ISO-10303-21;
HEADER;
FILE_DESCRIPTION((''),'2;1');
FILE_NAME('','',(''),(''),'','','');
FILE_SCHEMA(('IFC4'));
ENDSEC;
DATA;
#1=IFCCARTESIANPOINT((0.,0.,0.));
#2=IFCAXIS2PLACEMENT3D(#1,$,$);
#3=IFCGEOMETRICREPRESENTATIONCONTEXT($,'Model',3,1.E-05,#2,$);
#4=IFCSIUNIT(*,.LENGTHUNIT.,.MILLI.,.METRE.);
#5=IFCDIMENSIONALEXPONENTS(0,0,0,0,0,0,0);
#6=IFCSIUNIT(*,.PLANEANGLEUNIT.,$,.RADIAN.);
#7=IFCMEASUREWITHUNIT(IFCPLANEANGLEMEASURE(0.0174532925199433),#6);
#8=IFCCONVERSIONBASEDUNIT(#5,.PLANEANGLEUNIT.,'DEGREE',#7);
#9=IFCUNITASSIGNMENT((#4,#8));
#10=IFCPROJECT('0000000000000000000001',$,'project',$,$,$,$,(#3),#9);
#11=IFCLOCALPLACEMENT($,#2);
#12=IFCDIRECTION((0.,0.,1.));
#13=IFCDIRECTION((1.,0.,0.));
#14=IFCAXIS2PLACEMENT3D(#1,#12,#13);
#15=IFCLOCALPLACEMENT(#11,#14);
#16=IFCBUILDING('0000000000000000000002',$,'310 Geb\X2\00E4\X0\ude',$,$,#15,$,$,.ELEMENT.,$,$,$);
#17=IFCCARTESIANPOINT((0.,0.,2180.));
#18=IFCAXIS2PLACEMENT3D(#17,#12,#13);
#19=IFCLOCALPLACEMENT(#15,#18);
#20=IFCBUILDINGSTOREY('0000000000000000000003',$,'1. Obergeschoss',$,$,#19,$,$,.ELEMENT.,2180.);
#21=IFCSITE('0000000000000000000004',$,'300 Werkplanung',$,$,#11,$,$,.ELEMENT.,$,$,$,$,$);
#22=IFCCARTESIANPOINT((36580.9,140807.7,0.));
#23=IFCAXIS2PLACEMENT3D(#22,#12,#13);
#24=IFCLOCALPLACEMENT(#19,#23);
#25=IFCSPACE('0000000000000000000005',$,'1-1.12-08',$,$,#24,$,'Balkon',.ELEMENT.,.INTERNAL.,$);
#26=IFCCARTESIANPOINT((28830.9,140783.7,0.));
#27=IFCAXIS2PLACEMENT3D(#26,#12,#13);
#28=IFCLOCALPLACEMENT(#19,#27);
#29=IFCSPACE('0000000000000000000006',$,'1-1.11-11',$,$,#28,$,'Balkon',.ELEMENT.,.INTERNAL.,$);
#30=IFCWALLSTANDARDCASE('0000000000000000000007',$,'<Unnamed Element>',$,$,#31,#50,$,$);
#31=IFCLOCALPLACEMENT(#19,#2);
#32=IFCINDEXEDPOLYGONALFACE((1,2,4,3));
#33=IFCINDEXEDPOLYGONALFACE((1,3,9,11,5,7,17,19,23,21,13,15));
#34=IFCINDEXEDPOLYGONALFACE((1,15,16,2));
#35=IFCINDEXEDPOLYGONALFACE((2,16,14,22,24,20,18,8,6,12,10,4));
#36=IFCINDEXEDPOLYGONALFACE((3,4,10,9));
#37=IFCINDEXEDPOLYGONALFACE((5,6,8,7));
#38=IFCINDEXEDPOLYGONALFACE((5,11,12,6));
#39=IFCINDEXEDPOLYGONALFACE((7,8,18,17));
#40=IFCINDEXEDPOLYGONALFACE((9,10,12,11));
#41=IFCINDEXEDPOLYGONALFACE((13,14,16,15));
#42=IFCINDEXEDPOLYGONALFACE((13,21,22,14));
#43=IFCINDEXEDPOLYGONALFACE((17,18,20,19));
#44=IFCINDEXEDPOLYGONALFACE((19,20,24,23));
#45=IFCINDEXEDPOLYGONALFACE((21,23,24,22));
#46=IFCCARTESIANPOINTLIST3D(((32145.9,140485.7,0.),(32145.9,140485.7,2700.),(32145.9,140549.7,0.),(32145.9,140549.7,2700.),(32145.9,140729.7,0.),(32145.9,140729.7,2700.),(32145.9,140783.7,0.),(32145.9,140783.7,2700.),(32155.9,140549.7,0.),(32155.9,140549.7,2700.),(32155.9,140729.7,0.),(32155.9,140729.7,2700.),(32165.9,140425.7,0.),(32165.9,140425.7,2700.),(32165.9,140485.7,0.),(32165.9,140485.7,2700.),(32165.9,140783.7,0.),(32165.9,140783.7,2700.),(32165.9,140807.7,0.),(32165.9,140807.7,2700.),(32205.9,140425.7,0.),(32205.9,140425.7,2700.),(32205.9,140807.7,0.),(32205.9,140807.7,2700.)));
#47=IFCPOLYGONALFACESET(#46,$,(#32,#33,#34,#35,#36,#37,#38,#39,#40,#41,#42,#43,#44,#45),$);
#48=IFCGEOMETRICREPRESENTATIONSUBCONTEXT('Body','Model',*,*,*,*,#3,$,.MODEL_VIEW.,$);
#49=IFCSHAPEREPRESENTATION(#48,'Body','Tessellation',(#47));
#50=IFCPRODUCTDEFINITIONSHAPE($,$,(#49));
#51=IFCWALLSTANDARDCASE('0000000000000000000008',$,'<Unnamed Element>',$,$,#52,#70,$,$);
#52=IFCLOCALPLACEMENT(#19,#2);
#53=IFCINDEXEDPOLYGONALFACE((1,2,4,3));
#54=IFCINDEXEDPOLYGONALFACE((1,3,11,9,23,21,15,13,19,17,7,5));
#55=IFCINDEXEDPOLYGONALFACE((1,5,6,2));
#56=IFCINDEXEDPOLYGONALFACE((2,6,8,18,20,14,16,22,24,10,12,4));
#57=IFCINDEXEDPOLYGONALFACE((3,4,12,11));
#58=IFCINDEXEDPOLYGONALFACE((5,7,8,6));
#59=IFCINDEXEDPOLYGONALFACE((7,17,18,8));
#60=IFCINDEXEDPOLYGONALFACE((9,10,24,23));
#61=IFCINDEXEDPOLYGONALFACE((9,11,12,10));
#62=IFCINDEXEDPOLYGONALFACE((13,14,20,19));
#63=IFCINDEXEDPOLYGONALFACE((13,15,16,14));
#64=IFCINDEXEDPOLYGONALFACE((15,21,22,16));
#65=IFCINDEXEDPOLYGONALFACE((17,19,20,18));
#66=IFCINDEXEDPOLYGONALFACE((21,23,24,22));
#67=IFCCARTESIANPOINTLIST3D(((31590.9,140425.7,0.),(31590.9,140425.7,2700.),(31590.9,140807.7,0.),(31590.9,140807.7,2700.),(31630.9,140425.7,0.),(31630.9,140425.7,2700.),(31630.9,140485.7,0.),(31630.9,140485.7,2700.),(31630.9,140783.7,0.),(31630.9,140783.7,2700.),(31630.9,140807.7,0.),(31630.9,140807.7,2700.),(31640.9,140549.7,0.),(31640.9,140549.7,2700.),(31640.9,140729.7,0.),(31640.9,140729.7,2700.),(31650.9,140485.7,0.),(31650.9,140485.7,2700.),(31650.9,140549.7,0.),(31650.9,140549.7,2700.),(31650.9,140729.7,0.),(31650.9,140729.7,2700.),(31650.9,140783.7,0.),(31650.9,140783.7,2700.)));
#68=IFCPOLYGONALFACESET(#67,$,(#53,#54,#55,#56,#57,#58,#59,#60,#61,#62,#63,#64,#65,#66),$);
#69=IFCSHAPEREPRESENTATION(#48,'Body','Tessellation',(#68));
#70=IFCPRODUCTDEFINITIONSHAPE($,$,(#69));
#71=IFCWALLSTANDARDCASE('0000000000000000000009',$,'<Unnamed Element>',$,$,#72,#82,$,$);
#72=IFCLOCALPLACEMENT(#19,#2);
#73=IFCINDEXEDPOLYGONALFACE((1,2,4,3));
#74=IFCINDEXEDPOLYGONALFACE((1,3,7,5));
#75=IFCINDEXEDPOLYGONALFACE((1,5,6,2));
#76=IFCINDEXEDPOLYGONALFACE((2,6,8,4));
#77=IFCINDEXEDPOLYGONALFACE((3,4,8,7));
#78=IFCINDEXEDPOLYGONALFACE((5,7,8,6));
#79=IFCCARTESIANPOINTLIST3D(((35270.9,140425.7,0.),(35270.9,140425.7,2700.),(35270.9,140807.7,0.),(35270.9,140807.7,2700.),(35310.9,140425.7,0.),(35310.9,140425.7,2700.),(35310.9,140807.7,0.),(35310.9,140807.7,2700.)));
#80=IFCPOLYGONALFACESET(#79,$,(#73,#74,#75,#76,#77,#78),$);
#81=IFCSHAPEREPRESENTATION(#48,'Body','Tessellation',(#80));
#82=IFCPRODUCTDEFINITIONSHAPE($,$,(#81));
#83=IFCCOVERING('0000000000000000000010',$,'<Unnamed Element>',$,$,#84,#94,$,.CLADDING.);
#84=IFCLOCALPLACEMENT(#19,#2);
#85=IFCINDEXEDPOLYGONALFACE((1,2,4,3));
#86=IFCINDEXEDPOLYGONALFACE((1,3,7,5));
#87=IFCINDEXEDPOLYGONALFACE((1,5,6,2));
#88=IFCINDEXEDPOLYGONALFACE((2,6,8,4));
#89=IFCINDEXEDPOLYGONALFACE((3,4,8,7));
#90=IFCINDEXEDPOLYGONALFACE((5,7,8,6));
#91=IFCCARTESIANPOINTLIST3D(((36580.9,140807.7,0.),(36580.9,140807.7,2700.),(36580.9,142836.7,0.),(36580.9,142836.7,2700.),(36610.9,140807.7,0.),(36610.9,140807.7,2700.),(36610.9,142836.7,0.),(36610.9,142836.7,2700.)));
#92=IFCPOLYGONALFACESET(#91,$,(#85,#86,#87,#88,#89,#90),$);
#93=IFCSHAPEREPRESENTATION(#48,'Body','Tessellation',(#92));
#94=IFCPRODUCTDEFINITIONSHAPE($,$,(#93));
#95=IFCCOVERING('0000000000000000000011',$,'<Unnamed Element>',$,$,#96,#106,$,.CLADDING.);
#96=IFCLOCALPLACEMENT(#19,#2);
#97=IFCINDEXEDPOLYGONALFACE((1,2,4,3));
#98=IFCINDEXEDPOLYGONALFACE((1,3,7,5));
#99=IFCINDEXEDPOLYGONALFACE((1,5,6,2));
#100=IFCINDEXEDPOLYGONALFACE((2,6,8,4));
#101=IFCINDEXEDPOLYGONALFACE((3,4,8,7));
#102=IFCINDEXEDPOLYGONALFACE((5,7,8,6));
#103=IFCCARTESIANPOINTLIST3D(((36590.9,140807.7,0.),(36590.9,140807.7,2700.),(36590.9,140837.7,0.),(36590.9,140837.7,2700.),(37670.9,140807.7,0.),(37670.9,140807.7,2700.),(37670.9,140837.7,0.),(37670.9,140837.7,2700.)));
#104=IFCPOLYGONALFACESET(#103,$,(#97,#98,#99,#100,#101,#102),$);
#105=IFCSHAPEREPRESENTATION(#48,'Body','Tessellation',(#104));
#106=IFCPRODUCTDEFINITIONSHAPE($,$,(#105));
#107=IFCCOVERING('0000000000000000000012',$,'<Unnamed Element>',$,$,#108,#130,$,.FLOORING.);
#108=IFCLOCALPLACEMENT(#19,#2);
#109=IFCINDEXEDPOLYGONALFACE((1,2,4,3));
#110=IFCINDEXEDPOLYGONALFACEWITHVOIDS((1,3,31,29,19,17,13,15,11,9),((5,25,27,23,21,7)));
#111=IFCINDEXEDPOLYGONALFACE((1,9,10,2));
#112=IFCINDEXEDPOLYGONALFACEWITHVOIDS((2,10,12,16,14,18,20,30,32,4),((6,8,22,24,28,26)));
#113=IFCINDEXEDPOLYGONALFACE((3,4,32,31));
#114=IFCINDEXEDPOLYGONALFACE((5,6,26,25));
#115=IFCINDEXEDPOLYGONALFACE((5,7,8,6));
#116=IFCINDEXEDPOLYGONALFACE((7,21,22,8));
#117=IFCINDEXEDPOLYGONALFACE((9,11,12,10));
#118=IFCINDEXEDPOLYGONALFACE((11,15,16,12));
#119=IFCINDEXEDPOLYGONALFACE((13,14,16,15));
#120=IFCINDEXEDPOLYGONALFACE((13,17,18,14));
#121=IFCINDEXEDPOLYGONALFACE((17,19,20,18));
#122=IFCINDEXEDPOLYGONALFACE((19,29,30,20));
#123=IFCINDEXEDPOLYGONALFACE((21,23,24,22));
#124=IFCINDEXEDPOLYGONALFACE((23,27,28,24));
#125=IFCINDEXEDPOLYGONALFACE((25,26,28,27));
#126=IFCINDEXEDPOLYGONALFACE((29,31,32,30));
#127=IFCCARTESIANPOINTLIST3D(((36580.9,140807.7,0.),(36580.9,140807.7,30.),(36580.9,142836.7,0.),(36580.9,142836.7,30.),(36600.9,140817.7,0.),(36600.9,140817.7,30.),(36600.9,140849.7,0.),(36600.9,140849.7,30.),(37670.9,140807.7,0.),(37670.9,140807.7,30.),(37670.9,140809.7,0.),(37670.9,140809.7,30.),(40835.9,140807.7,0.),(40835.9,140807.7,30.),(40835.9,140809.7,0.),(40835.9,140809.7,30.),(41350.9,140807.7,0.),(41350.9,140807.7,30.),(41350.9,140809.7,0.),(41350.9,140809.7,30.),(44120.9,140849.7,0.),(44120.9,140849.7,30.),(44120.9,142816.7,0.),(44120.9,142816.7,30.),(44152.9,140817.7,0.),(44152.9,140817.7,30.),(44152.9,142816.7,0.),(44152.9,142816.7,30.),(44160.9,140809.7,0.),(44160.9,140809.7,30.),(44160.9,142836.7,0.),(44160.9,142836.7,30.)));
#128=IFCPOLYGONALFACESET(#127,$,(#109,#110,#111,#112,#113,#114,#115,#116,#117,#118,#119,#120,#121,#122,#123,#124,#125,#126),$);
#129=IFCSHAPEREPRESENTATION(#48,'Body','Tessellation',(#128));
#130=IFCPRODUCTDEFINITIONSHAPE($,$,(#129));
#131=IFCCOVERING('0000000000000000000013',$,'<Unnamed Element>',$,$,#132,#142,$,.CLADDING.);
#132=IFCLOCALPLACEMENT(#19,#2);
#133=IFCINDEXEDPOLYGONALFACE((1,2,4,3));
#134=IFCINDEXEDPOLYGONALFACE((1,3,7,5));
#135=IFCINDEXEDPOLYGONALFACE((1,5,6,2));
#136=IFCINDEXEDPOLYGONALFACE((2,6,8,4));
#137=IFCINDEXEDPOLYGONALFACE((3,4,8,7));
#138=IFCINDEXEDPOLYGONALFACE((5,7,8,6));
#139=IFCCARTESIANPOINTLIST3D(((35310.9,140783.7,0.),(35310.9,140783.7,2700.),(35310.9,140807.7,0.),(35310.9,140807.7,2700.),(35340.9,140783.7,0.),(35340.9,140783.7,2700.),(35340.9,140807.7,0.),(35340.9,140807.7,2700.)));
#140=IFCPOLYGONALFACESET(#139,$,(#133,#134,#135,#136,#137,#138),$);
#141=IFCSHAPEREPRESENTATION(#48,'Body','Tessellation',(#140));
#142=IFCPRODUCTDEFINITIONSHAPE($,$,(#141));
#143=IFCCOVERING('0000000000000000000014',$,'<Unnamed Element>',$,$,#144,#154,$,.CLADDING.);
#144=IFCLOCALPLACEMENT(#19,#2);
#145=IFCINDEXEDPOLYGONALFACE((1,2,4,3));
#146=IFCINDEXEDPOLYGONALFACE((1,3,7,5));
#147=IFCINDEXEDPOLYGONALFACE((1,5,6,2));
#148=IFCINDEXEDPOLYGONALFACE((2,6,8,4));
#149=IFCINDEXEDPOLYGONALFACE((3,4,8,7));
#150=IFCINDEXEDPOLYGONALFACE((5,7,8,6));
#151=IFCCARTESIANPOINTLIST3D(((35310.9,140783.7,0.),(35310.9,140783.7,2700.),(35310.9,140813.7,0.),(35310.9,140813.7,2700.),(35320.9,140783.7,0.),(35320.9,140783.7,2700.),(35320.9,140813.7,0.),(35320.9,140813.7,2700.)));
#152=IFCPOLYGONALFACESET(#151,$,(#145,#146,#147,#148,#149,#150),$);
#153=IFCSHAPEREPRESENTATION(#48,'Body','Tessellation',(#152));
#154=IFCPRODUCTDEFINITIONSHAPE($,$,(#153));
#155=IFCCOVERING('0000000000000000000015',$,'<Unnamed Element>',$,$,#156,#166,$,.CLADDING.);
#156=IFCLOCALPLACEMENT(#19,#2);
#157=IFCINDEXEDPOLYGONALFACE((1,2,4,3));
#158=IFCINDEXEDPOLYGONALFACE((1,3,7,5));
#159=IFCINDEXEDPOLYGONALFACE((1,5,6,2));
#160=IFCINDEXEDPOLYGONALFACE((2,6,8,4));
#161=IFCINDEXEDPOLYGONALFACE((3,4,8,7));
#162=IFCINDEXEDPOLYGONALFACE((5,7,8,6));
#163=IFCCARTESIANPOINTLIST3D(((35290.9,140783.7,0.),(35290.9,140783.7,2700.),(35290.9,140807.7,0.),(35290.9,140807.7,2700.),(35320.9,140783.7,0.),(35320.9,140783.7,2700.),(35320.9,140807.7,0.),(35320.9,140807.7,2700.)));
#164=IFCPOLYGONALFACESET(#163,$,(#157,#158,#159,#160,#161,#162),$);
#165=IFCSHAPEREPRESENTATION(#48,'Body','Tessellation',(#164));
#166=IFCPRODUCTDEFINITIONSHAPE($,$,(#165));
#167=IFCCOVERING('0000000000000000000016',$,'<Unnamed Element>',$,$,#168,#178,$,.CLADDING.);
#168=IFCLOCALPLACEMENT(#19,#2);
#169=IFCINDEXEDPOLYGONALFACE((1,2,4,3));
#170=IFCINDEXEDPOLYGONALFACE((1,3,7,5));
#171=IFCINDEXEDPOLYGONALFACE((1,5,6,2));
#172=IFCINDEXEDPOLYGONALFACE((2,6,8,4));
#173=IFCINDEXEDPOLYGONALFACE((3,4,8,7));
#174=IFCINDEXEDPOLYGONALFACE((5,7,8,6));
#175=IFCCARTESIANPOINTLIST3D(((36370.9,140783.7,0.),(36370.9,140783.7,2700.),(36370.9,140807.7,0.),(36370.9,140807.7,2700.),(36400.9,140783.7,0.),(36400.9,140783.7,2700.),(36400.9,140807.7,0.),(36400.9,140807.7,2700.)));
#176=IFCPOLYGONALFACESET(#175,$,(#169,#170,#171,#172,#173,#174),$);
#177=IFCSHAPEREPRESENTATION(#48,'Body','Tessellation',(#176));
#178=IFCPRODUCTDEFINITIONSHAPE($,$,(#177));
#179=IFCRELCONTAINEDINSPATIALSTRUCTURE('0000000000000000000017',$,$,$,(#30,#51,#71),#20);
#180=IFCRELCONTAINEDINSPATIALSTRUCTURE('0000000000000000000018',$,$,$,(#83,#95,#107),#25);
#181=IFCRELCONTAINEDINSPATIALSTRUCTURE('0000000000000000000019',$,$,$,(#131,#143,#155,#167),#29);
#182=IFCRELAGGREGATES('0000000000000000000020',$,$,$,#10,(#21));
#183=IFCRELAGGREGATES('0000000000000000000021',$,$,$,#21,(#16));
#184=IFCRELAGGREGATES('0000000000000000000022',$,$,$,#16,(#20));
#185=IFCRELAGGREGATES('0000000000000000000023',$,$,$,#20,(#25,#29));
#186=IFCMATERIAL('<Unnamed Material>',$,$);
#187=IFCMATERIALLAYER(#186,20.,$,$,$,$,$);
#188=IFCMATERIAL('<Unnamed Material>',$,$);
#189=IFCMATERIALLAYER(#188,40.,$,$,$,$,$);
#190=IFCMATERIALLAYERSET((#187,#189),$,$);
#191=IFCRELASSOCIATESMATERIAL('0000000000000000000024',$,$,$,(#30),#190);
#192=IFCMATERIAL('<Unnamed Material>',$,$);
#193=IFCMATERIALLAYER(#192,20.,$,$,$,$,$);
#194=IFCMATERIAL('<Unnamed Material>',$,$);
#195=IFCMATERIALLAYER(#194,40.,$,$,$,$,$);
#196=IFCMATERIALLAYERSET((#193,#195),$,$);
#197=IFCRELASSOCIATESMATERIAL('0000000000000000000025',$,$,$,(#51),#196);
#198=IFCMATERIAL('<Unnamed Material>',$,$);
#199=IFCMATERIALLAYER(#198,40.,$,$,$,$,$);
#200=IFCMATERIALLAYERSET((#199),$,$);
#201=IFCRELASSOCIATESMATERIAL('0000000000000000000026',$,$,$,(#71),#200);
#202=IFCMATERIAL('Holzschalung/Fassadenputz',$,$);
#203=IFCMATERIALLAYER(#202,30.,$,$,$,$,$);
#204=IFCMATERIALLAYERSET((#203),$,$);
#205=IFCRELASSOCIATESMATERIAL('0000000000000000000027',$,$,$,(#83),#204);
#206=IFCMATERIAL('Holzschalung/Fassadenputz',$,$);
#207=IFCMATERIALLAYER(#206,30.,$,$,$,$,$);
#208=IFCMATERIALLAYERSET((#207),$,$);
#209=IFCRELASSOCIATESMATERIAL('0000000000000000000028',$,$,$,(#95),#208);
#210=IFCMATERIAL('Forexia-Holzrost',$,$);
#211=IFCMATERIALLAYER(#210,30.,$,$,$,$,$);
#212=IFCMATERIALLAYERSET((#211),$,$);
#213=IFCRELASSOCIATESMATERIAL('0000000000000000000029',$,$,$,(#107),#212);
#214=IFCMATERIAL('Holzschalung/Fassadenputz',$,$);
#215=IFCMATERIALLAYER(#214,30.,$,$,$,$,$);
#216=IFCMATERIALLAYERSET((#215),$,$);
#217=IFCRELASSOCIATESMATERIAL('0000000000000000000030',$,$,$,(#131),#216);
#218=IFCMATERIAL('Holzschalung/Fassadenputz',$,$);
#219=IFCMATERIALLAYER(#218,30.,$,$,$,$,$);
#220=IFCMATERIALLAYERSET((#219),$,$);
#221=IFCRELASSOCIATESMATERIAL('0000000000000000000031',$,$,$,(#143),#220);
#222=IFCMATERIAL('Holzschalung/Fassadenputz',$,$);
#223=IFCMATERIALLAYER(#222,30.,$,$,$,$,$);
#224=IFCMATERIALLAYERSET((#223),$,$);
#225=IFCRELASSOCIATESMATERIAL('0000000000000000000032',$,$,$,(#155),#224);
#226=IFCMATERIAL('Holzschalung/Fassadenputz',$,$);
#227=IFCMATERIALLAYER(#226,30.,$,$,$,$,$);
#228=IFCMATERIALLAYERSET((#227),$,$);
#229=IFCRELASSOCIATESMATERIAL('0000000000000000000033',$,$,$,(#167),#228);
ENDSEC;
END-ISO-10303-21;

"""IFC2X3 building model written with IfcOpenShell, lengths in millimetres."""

from ifc_helpers import new_model, entity, si_unit, converted_unit, frame, frame_2d, origin, origin_with_axes, place, context, subcontext, project, spatial, polyline, rectangle, outline, extrude, material, layer, layer_set, layer_usage, element, save


model = new_model("IFC2X3")

# Units and contexts
model_context = context("Model", 3, precision=1e-05, world=origin())
body_context = subcontext(model_context, "Body", "Model", "MODEL_VIEW")
ifc_project = project(units=[si_unit("LENGTHUNIT", "METRE", prefix="MILLI"), converted_unit("PLANEANGLEUNIT", "DEGREE", entity("IfcPlaneAngleMeasure", 0.0174532925199433), si_unit("PLANEANGLEUNIT", "RADIAN"), dimensions=[0, 0, 0, 0, 0, 0, 0])], contexts=[model_context])

# Site, building, storey
site_placement = place(None, origin())
site = spatial("IfcSite", under=ifc_project, at=site_placement, Name="300 Werkplanung", CompositionType="ELEMENT")
building_placement = place(site_placement, origin_with_axes())
building = spatial("IfcBuilding", under=site, at=building_placement, Name="310 Gebäude", CompositionType="ELEMENT")
storey_placement = place(building_placement, frame((0.0, 0.0, 2180.0), z_axis=(0.0, 0.0, 1.0), x_axis=(1.0, 0.0, 0.0)))
storey = spatial("IfcBuildingStorey", under=building, at=storey_placement, Name="1. Obergeschoss", CompositionType="ELEMENT", Elevation=2180.0)

# Walls
ifc_material_1 = material(Name="<Unnamed Material>")
ifc_layer_1 = layer(ifc_material_1, 20.0)
ifc_material_2 = material(Name="<Unnamed Material>")
ifc_layer_2 = layer(ifc_material_2, 40.0)
ifc_layer_set_1 = layer_set([ifc_layer_1, ifc_layer_2])
ifc_layer_usage_1 = layer_usage(ifc_layer_set_1, "AXIS2", "POSITIVE", -60.0)
wall_1_placement = place(storey_placement, frame((32145.9, 140783.7, 0.0), z_axis=(0.0, 0.0, 1.0), x_axis=(0.0, -1.0, 0.0)))
element("IfcWallStandardCase", 1, at=wall_1_placement, inside=storey, material=ifc_layer_usage_1, Name="<Unnamed Element>", context=body_context, shape_type="SweptSolid", body=[
    extrude(outline(polyline([(234.0, 0.0), (298.0, 0.0), (298.0, 20.0), (358.0, 20.0), (358.0, 60.0), (-24.0, 60.0), (-24.0, 20.0), (0.0, 20.0), (0.0, 0.0), (54.0, 0.0), (54.0, 10.0), (234.0, 10.0), (234.0, 0.0)])), origin_with_axes(), (0.0, 0.0, 1.0), 2700.0),
])
ifc_material_3 = material(Name="<Unnamed Material>")
ifc_layer_3 = layer(ifc_material_3, 20.0)
ifc_material_4 = material(Name="<Unnamed Material>")
ifc_layer_4 = layer(ifc_material_4, 40.0)
ifc_layer_set_2 = layer_set([ifc_layer_3, ifc_layer_4])
ifc_layer_usage_2 = layer_usage(ifc_layer_set_2, "AXIS2", "POSITIVE", -60.0)
wall_2_placement = place(storey_placement, frame((31650.9, 140485.7, 0.0), z_axis=(0.0, 0.0, 1.0), x_axis=(0.0, 1.0, 0.0)))
element("IfcWallStandardCase", 2, at=wall_2_placement, inside=storey, material=ifc_layer_usage_2, Name="<Unnamed Element>", context=body_context, shape_type="SweptSolid", body=[
    extrude(outline(polyline([(0.0, 0.0), (64.0, 0.0), (64.0, 10.0), (244.0, 10.0), (244.0, 0.0), (298.0, 0.0), (298.0, 20.0), (322.0, 20.0), (322.0, 60.0), (-60.0, 60.0), (-60.0, 20.0), (0.0, 20.0), (0.0, 0.0)])), origin_with_axes(), (0.0, 0.0, 1.0), 2700.0),
])
ifc_material_5 = material(Name="<Unnamed Material>")
ifc_layer_5 = layer(ifc_material_5, 40.0)
ifc_layer_set_3 = layer_set([ifc_layer_5])
ifc_layer_usage_3 = layer_usage(ifc_layer_set_3, "AXIS2", "POSITIVE", -40.0)
wall_3_placement = place(storey_placement, frame((35310.9, 140425.7, 0.0), z_axis=(0.0, 0.0, 1.0), x_axis=(0.0, 1.0, 0.0)))
element("IfcWallStandardCase", 3, at=wall_3_placement, inside=storey, material=ifc_layer_usage_3, Name="<Unnamed Element>", context=body_context, shape_type="SweptSolid", body=[
    extrude(rectangle(XDim=382.0, YDim=40.0, at=frame_2d((191.0, 20.0), x_axis=(1.0, 0.0))), origin_with_axes(), (0.0, 0.0, 1.0), 2700.0),
])

# Shared definitions
space_1_placement = place(storey_placement, frame((36580.9, 140807.7, 0.0), z_axis=(0.0, 0.0, 1.0), x_axis=(1.0, 0.0, 0.0)))
space_1 = spatial("IfcSpace", under=storey, at=space_1_placement, Name="1-1.12-08", LongName="Balkon", CompositionType="ELEMENT", InteriorOrExteriorSpace="INTERNAL")

# Coverings
ifc_material_6 = material(Name="Holzschalung/Fassadenputz")
ifc_layer_6 = layer(ifc_material_6, 30.0)
ifc_layer_set_4 = layer_set([ifc_layer_6])
ifc_layer_usage_4 = layer_usage(ifc_layer_set_4, "AXIS3", "POSITIVE", 0.0)
covering_1_placement = place(space_1_placement, frame((0.0, 2029.0, 0.0), z_axis=(0.0, 0.0, 1.0), x_axis=(0.0, -1.0, 0.0)))
element("IfcCovering", 4, at=covering_1_placement, inside=space_1, material=ifc_layer_usage_4, Name="<Unnamed Element>", PredefinedType="CLADDING", context=body_context, shape_type="SweptSolid", body=[
    extrude(rectangle(XDim=2029.0, YDim=2700.0, at=frame_2d((-1014.5, -1350.0), x_axis=(-1.0, 0.0))), frame((2029.0, 0.0, 0.0), z_axis=(0.0, 1.0, 0.0), x_axis=(1.0, 0.0, 0.0)), (0.0, 0.0, 1.0), 30.0),
])
ifc_material_7 = material(Name="Holzschalung/Fassadenputz")
ifc_layer_7 = layer(ifc_material_7, 30.0)
ifc_layer_set_5 = layer_set([ifc_layer_7])
ifc_layer_usage_5 = layer_usage(ifc_layer_set_5, "AXIS3", "POSITIVE", 0.0)
covering_2_placement = place(space_1_placement, frame((10.0, 0.0, 0.0), z_axis=(0.0, 0.0, 1.0), x_axis=(1.0, 0.0, 0.0)))
element("IfcCovering", 5, at=covering_2_placement, inside=space_1, material=ifc_layer_usage_5, Name="<Unnamed Element>", PredefinedType="CLADDING", context=body_context, shape_type="SweptSolid", body=[
    extrude(rectangle(XDim=1080.0, YDim=2700.0, at=frame_2d((-540.0, -1350.0), x_axis=(-1.0, 0.0))), frame((1080.0, 0.0, 0.0), z_axis=(0.0, 1.0, 0.0), x_axis=(1.0, 0.0, 0.0)), (0.0, 0.0, 1.0), 30.0),
])
ifc_material_8 = material(Name="Forexia-Holzrost")
ifc_layer_8 = layer(ifc_material_8, 30.0)
ifc_layer_set_6 = layer_set([ifc_layer_8])
ifc_layer_usage_6 = layer_usage(ifc_layer_set_6, "AXIS3", "POSITIVE", 0.0)
covering_3_placement = place(space_1_placement, origin_with_axes())
element("IfcCovering", 6, at=covering_3_placement, inside=space_1, material=ifc_layer_usage_6, Name="<Unnamed Element>", PredefinedType="FLOORING", context=body_context, shape_type="SweptSolid", body=[
    extrude(outline(polyline([(1090.0, 2.0), (4255.0, 2.0), (4255.0, 0.0), (4770.0, 0.0), (4770.0, 2.0), (7580.0, 2.0), (7580.0, 2029.0), (0.0, 2029.0), (0.0, 0.0), (1090.0, 0.0), (1090.0, 2.0)]), holes=[polyline([(7572.0, 10.0), (20.0, 10.0), (20.0, 42.0), (7540.0, 42.0), (7540.0, 2009.0), (7572.0, 2009.0), (7572.0, 10.0)])]), origin_with_axes(), (0.0, 0.0, 1.0), 30.0),
])

# Shared definitions
space_2_placement = place(storey_placement, frame((28830.9, 140783.7, 0.0), z_axis=(0.0, 0.0, 1.0), x_axis=(1.0, 0.0, 0.0)))
space_2 = spatial("IfcSpace", under=storey, at=space_2_placement, Name="1-1.11-11", LongName="Balkon", CompositionType="ELEMENT", InteriorOrExteriorSpace="INTERNAL")

# Coverings
ifc_material_9 = material(Name="Holzschalung/Fassadenputz")
ifc_layer_9 = layer(ifc_material_9, 30.0)
ifc_layer_set_7 = layer_set([ifc_layer_9])
ifc_layer_usage_7 = layer_usage(ifc_layer_set_7, "AXIS3", "POSITIVE", 0.0)
covering_4_placement = place(space_2_placement, frame((6480.0, 24.0, 0.0), z_axis=(0.0, 0.0, 1.0), x_axis=(0.0, -1.0, 0.0)))
element("IfcCovering", 7, at=covering_4_placement, inside=space_2, material=ifc_layer_usage_7, Name="<Unnamed Element>", PredefinedType="CLADDING", context=body_context, shape_type="SweptSolid", body=[
    extrude(rectangle(XDim=2700.0, YDim=24.0, at=frame_2d((-12.0, 1350.0), x_axis=(0.0, 1.0))), frame((24.0, 0.0, 2700.0), z_axis=(0.0, 1.0, 0.0), x_axis=(1.0, 0.0, 0.0)), (0.0, 0.0, 1.0), 30.0),
])
ifc_material_10 = material(Name="Holzschalung/Fassadenputz")
ifc_layer_10 = layer(ifc_material_10, 30.0)
ifc_layer_set_8 = layer_set([ifc_layer_10])
ifc_layer_usage_8 = layer_usage(ifc_layer_set_8, "AXIS3", "POSITIVE", 0.0)
covering_5_placement = place(space_2_placement, frame((6480.0, 0.0, 0.0), z_axis=(0.0, 0.0, 1.0), x_axis=(1.0, 0.0, 0.0)))
element("IfcCovering", 8, at=covering_5_placement, inside=space_2, material=ifc_layer_usage_8, Name="<Unnamed Element>", PredefinedType="CLADDING", context=body_context, shape_type="SweptSolid", body=[
    extrude(rectangle(XDim=2700.0, YDim=10.0, at=frame_2d((-5.0, 1350.0), x_axis=(0.0, 1.0))), frame((10.0, 0.0, 2700.0), z_axis=(0.0, 1.0, 0.0), x_axis=(1.0, 0.0, 0.0)), (0.0, 0.0, 1.0), 30.0),
])
ifc_material_11 = material(Name="Holzschalung/Fassadenputz")
ifc_layer_11 = layer(ifc_material_11, 30.0)
ifc_layer_set_9 = layer_set([ifc_layer_11])
ifc_layer_usage_9 = layer_usage(ifc_layer_set_9, "AXIS3", "POSITIVE", 0.0)
covering_6_placement = place(space_2_placement, frame((6490.0, 0.0, 0.0), z_axis=(0.0, 0.0, 1.0), x_axis=(0.0, 1.0, 0.0)))
element("IfcCovering", 9, at=covering_6_placement, inside=space_2, material=ifc_layer_usage_9, Name="<Unnamed Element>", PredefinedType="CLADDING", context=body_context, shape_type="SweptSolid", body=[
    extrude(rectangle(XDim=2700.0, YDim=24.0, at=frame_2d((-12.0, 1350.0), x_axis=(0.0, 1.0))), frame((24.0, 0.0, 2700.0), z_axis=(0.0, 1.0, 0.0), x_axis=(1.0, 0.0, 0.0)), (0.0, 0.0, 1.0), 30.0),
])
ifc_material_12 = material(Name="Holzschalung/Fassadenputz")
ifc_layer_12 = layer(ifc_material_12, 30.0)
ifc_layer_set_10 = layer_set([ifc_layer_12])
ifc_layer_usage_10 = layer_usage(ifc_layer_set_10, "AXIS3", "POSITIVE", 0.0)
covering_7_placement = place(space_2_placement, frame((7540.0, 24.0, 0.0), z_axis=(0.0, 0.0, 1.0), x_axis=(0.0, -1.0, 0.0)))
element("IfcCovering", 10, at=covering_7_placement, inside=space_2, material=ifc_layer_usage_10, Name="<Unnamed Element>", PredefinedType="CLADDING", context=body_context, shape_type="SweptSolid", body=[
    extrude(rectangle(XDim=2700.0, YDim=24.0, at=frame_2d((-12.0, 1350.0), x_axis=(0.0, 1.0))), frame((24.0, 0.0, 2700.0), z_axis=(0.0, 1.0, 0.0), x_axis=(1.0, 0.0, 0.0)), (0.0, 0.0, 1.0), 30.0),
])

save(model, "model.ifc")
